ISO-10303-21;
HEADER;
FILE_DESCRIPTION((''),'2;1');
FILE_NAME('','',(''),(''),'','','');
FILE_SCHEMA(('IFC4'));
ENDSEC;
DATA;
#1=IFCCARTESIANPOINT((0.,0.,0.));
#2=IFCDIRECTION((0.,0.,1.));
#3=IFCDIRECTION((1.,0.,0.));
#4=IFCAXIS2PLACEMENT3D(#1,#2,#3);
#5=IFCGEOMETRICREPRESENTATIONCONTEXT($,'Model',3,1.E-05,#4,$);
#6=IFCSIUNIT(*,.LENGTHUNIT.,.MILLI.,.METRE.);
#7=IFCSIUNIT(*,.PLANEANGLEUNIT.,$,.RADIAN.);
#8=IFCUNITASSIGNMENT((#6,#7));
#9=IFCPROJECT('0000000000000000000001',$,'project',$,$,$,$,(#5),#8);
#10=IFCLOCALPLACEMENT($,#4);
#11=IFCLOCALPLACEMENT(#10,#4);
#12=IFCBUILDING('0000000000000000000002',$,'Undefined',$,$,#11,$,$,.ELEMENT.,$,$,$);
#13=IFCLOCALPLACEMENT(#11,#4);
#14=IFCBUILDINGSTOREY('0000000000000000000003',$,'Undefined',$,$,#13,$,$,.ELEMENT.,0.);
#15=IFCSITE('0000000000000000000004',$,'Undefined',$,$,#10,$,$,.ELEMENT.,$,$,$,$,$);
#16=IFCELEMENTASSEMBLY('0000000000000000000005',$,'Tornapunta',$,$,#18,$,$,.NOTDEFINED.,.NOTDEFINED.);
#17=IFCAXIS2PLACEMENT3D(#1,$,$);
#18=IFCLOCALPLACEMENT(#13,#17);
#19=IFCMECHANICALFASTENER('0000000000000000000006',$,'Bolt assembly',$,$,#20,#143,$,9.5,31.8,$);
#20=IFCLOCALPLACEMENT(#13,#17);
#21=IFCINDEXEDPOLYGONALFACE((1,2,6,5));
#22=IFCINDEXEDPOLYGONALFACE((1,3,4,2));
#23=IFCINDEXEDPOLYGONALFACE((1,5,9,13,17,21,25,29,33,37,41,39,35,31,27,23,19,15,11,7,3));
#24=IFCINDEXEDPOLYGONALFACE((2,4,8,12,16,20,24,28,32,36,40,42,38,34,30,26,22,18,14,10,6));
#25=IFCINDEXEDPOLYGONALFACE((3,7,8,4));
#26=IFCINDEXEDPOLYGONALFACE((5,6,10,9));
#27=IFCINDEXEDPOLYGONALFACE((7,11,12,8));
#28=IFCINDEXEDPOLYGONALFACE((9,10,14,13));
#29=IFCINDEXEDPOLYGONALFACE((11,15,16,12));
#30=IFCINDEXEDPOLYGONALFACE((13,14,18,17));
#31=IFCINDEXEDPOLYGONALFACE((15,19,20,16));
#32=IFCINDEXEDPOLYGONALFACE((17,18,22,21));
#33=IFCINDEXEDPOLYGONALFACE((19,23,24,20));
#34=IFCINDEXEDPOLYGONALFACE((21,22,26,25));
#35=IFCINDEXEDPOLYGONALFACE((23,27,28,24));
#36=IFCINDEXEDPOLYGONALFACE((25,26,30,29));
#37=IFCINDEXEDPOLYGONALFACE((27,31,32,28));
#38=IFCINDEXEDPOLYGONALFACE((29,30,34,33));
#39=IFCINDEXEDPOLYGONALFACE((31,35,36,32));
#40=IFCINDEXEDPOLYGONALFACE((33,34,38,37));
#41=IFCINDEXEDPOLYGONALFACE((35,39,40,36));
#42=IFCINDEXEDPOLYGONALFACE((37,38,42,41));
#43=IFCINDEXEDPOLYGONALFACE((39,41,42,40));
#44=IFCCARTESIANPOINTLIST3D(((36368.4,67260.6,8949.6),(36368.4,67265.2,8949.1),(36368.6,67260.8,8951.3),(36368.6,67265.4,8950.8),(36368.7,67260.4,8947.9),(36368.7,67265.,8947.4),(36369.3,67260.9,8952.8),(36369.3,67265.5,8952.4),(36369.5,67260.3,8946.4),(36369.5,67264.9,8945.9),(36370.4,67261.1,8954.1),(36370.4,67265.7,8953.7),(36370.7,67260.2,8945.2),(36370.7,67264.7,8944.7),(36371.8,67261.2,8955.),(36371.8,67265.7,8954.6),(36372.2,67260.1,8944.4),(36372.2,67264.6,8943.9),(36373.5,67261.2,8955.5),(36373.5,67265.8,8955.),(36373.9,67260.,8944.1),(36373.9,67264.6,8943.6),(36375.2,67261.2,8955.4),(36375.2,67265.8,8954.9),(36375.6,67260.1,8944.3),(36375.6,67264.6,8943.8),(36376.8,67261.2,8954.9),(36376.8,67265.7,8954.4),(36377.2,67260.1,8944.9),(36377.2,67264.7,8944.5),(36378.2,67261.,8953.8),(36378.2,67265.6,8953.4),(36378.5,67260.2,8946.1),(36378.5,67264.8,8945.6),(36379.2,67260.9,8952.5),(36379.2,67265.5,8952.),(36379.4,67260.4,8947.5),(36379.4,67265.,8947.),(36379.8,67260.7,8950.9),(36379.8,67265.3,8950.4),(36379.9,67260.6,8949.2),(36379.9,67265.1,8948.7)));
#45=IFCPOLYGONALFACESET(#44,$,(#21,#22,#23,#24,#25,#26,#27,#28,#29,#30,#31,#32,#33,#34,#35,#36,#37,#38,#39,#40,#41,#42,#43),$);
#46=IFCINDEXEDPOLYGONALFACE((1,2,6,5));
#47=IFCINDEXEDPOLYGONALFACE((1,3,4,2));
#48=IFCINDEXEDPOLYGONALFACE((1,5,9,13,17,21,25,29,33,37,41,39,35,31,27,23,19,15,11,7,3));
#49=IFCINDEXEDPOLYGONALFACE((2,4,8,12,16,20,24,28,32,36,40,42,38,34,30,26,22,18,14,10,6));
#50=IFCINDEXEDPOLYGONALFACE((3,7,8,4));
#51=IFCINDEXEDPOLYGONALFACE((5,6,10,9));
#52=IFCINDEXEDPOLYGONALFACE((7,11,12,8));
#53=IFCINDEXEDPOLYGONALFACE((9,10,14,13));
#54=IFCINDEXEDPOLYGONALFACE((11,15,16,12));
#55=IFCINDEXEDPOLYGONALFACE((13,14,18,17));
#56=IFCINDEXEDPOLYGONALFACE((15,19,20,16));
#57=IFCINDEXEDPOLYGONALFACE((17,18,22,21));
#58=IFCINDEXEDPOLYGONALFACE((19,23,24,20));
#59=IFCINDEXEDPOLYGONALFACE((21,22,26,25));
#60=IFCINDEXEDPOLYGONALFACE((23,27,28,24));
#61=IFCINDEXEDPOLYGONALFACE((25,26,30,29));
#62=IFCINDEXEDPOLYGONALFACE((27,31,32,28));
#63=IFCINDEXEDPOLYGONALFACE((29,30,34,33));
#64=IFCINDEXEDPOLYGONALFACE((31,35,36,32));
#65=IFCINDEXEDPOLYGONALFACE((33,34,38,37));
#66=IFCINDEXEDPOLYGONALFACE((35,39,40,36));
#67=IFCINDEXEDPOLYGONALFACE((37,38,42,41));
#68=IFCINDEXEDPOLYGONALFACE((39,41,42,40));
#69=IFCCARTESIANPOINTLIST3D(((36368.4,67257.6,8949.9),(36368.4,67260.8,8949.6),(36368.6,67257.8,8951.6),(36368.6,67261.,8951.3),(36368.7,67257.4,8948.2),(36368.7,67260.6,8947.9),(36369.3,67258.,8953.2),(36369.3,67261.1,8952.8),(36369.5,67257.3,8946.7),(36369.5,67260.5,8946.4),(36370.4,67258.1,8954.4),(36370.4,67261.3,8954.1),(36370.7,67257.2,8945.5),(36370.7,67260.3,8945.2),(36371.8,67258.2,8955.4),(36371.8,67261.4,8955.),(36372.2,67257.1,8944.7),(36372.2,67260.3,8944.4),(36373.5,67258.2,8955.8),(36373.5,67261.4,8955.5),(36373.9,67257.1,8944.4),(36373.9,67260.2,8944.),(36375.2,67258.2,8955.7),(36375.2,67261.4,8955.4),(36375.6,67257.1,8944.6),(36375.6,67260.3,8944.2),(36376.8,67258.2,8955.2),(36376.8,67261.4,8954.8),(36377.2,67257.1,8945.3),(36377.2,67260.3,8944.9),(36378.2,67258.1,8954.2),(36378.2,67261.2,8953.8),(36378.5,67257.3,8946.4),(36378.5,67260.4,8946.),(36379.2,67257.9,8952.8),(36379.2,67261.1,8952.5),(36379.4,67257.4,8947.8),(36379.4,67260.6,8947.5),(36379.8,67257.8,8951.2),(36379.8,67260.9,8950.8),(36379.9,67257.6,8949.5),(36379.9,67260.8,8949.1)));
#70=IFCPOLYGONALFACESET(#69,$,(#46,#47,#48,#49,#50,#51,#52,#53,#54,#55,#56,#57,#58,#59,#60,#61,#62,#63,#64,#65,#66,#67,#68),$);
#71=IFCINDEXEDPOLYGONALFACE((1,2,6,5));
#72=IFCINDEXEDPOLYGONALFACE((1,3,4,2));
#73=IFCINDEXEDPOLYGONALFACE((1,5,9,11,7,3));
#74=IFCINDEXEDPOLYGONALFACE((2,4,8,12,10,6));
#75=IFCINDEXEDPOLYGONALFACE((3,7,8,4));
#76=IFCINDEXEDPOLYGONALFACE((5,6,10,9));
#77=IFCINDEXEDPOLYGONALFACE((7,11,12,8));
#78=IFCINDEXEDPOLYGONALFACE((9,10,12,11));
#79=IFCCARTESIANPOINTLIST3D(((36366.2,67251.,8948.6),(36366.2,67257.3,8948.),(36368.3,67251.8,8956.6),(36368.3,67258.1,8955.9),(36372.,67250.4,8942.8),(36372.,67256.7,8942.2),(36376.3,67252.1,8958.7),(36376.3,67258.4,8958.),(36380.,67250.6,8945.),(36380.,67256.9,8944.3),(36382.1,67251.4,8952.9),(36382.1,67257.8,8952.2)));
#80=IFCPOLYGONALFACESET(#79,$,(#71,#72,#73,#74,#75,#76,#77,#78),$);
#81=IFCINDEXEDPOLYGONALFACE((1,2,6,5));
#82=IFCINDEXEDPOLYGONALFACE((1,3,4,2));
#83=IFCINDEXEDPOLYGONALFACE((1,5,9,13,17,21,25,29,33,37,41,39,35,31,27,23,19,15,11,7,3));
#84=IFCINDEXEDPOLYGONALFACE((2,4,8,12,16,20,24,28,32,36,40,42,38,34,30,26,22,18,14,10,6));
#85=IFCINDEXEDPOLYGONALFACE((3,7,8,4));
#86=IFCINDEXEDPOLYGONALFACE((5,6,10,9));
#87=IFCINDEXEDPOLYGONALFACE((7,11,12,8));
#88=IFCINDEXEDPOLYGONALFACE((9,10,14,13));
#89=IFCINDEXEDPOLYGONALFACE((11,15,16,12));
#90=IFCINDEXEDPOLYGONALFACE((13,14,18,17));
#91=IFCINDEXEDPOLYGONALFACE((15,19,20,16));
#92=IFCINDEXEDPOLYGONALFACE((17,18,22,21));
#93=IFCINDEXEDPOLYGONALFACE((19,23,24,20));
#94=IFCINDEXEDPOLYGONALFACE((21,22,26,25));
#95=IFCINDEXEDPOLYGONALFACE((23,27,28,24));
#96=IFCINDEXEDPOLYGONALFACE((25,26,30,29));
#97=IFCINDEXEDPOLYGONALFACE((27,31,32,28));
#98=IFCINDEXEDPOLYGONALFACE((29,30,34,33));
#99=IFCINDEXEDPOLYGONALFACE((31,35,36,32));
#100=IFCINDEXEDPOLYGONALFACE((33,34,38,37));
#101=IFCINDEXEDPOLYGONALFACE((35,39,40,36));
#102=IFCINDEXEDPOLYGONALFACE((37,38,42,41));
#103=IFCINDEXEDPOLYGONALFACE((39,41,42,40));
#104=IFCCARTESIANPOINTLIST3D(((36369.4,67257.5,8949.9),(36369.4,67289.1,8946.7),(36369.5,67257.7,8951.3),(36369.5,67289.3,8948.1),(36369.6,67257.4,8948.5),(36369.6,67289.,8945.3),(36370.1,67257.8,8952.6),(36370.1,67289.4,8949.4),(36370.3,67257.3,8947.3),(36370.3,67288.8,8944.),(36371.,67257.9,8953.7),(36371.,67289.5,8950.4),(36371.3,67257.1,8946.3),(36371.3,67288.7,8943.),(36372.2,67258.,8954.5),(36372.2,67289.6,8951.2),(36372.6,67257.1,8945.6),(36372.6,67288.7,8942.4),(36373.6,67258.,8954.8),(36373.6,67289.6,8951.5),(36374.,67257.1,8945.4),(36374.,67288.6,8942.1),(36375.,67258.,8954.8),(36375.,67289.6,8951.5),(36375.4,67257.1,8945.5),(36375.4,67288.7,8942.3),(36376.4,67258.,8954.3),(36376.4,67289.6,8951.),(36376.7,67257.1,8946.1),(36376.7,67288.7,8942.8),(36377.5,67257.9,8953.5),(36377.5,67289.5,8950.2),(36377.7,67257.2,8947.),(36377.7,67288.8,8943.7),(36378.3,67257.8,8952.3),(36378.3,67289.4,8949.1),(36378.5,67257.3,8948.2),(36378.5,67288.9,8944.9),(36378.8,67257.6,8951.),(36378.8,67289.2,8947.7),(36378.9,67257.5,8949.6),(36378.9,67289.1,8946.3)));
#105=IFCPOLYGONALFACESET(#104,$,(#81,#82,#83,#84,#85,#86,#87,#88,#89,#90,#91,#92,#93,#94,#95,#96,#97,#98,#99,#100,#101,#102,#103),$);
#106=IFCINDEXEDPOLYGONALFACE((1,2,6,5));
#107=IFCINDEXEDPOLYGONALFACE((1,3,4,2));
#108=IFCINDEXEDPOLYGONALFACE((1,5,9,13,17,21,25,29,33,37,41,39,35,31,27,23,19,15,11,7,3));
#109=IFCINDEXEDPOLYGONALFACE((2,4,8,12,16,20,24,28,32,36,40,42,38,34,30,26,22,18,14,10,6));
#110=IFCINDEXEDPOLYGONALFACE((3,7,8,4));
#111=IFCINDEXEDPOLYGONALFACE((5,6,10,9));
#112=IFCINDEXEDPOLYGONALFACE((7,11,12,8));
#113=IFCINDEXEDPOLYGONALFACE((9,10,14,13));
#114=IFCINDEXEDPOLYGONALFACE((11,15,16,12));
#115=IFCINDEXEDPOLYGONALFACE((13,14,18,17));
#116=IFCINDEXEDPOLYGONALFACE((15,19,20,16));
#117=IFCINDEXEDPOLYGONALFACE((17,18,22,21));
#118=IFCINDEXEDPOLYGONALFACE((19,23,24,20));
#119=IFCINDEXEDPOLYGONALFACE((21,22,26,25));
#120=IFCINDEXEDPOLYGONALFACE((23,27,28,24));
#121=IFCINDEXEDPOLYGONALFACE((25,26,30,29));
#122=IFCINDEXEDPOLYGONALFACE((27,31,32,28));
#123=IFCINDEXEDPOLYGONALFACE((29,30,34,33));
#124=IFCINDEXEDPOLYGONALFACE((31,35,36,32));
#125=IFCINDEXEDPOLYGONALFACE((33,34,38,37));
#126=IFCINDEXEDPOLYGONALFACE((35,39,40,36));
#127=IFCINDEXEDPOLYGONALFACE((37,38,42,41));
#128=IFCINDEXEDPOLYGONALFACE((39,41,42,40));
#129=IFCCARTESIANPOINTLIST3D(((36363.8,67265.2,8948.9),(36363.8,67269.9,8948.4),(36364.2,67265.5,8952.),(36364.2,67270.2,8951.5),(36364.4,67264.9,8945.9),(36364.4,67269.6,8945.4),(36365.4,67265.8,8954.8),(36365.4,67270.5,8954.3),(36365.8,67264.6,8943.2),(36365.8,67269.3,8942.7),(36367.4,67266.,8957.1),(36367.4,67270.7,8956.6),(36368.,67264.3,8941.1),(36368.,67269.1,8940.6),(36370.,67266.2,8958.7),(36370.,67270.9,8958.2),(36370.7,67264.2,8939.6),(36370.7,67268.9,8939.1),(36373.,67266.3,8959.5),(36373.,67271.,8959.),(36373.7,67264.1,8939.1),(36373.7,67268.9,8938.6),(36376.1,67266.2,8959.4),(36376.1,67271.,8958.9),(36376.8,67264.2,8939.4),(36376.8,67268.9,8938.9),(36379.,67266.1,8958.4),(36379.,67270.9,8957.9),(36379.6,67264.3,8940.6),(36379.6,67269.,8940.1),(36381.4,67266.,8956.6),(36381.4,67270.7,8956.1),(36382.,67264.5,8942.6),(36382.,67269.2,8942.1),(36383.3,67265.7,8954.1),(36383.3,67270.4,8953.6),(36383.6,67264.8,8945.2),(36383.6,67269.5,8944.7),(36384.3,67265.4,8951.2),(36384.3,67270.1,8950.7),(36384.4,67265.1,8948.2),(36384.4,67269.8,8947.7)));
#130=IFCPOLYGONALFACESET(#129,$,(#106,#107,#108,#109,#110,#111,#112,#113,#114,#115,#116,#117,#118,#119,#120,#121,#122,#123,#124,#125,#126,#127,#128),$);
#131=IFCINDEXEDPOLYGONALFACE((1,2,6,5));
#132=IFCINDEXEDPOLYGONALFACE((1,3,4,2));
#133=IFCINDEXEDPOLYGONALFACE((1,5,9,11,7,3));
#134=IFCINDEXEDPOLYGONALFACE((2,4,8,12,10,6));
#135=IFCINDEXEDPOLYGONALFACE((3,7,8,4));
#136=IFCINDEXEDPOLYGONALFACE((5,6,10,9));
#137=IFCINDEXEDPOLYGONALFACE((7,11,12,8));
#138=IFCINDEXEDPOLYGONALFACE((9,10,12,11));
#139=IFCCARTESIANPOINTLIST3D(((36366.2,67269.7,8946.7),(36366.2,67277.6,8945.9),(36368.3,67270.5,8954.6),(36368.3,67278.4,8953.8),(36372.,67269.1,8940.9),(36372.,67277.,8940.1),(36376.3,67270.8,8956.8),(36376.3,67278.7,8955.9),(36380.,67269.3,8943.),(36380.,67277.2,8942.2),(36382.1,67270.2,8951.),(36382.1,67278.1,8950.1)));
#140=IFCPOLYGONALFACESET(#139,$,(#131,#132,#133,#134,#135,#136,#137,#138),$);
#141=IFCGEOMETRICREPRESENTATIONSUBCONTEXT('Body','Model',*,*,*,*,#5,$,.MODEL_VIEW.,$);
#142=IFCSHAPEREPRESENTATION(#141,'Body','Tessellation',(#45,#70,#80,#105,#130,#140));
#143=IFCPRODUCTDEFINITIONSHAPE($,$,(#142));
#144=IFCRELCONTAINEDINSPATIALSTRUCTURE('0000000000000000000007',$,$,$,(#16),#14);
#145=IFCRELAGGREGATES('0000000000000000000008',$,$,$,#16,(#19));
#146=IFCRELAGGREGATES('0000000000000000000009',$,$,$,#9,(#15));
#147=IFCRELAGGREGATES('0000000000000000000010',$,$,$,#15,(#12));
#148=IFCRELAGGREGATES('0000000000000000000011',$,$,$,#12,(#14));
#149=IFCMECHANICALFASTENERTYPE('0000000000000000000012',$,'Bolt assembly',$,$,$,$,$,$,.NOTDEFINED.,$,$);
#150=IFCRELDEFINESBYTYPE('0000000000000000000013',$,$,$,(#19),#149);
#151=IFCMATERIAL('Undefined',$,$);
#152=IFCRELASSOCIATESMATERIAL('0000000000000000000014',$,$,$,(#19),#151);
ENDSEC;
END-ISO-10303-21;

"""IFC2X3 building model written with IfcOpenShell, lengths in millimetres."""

from ifc_helpers import new_model, si_unit, frame, origin_with_axes, origin_2d_with_axis, place, context, subcontext, project, spatial, polyline, circle, outline, extrude, source, transform, mapped, material, type_object, element, aggregate, save


model = new_model("IFC2X3")

# Units and contexts
model_context = context("Model", 3, precision=1e-05, world=origin_with_axes())
body_context = subcontext(model_context, "Body", "Model", "MODEL_VIEW")
ifc_project = project(units=[si_unit("LENGTHUNIT", "METRE", prefix="MILLI"), si_unit("PLANEANGLEUNIT", "RADIAN")], contexts=[model_context])

# Site, building, storey
site_placement = place(None, origin_with_axes())
site = spatial("IfcSite", under=ifc_project, at=site_placement, Name="Undefined", CompositionType="ELEMENT")
building_placement = place(site_placement, origin_with_axes())
building = spatial("IfcBuilding", under=site, at=building_placement, Name="Undefined", CompositionType="ELEMENT")
storey_placement = place(building_placement, origin_with_axes())
storey = spatial("IfcBuildingStorey", under=building, at=storey_placement, Name="Undefined", CompositionType="ELEMENT", Elevation=0.0)

# Shared definitions
ifc_material_1 = material(Name="Undefined")
mechanical_fastener_type = type_object("IfcMechanicalFastenerType", Name="Bolt assembly")

# Shared definitions
shared_shape_1 = source(origin_with_axes(), body_context, "Body", "SweptSolid", [
    extrude(circle(Radius=5.8, at=origin_2d_with_axis()), frame((0.0, -0.1, 0.0), z_axis=(0.0, 1.0, 0.0), x_axis=(1.0, 0.0, 0.0)), (0.0, 0.0, 1.0), 4.6),
    extrude(circle(Radius=5.8, at=origin_2d_with_axis()), frame((0.0, -3.1, 0.0), z_axis=(0.0, 1.0, 0.0), x_axis=(1.0, 0.0, 0.0)), (0.0, 0.0, 1.0), 3.2),
    extrude(outline(polyline([(7.1, -4.1), (7.1, 4.1), (0.0, 8.2), (-7.1, 4.1), (-7.1, -4.1), (0.0, -8.2), (7.1, -4.1)])), frame((0.0, -9.5, 0.0), z_axis=(0.0, 1.0, 0.0), x_axis=(1.0, 0.0, 0.0)), (0.0, 0.0, 1.0), 6.3),
    extrude(circle(Radius=4.8, at=origin_2d_with_axis()), frame((0.0, -3.2, 0.0), z_axis=(0.0, 1.0, 0.0), x_axis=(1.0, 0.0, 0.0)), (0.0, 0.0, 1.0), 31.8),
    extrude(circle(Radius=10.3, at=origin_2d_with_axis()), frame((0.0, 4.5, 0.0), z_axis=(0.0, 1.0, 0.0), x_axis=(1.0, 0.0, 0.0)), (0.0, 0.0, 1.0), 4.8),
    extrude(outline(polyline([(7.1, -4.1), (7.1, 4.1), (0.0, 8.2), (-7.1, 4.1), (-7.1, -4.1), (0.0, -8.2), (7.1, -4.1)])), frame((0.0, 9.3, 0.0), z_axis=(0.0, 1.0, 0.0), x_axis=(1.0, 0.0, 0.0)), (0.0, 0.0, 1.0), 7.9),
])

# Element assembly, mechanical fastener
assembly_1_placement = place(storey_placement, origin_with_axes())
assembly_1 = element("IfcElementAssembly", 1, at=assembly_1_placement, inside=storey, Name="Tornapunta", AssemblyPlace="NOTDEFINED", PredefinedType="NOTDEFINED")
mechanical_fastener_1_placement = place(assembly_1_placement, frame((36374.1, 67260.7, 8949.8), z_axis=(-0.707107, 0.072947, 0.703334), x_axis=(0.707107, 0.072947, 0.703334)))
mechanical_fastener_1 = element("IfcMechanicalFastener", 2, at=mechanical_fastener_1_placement, type_object=mechanical_fastener_type, material=ifc_material_1, Name="Bolt assembly", NominalDiameter=9.5, NominalLength=31.8, context=body_context, shape_type="MappedRepresentation", body=[
    mapped(shared_shape_1, transform((0.0, 0.0, 0.0))),
])
aggregate(assembly_1, [mechanical_fastener_1])

save(model, "model.ifc")
